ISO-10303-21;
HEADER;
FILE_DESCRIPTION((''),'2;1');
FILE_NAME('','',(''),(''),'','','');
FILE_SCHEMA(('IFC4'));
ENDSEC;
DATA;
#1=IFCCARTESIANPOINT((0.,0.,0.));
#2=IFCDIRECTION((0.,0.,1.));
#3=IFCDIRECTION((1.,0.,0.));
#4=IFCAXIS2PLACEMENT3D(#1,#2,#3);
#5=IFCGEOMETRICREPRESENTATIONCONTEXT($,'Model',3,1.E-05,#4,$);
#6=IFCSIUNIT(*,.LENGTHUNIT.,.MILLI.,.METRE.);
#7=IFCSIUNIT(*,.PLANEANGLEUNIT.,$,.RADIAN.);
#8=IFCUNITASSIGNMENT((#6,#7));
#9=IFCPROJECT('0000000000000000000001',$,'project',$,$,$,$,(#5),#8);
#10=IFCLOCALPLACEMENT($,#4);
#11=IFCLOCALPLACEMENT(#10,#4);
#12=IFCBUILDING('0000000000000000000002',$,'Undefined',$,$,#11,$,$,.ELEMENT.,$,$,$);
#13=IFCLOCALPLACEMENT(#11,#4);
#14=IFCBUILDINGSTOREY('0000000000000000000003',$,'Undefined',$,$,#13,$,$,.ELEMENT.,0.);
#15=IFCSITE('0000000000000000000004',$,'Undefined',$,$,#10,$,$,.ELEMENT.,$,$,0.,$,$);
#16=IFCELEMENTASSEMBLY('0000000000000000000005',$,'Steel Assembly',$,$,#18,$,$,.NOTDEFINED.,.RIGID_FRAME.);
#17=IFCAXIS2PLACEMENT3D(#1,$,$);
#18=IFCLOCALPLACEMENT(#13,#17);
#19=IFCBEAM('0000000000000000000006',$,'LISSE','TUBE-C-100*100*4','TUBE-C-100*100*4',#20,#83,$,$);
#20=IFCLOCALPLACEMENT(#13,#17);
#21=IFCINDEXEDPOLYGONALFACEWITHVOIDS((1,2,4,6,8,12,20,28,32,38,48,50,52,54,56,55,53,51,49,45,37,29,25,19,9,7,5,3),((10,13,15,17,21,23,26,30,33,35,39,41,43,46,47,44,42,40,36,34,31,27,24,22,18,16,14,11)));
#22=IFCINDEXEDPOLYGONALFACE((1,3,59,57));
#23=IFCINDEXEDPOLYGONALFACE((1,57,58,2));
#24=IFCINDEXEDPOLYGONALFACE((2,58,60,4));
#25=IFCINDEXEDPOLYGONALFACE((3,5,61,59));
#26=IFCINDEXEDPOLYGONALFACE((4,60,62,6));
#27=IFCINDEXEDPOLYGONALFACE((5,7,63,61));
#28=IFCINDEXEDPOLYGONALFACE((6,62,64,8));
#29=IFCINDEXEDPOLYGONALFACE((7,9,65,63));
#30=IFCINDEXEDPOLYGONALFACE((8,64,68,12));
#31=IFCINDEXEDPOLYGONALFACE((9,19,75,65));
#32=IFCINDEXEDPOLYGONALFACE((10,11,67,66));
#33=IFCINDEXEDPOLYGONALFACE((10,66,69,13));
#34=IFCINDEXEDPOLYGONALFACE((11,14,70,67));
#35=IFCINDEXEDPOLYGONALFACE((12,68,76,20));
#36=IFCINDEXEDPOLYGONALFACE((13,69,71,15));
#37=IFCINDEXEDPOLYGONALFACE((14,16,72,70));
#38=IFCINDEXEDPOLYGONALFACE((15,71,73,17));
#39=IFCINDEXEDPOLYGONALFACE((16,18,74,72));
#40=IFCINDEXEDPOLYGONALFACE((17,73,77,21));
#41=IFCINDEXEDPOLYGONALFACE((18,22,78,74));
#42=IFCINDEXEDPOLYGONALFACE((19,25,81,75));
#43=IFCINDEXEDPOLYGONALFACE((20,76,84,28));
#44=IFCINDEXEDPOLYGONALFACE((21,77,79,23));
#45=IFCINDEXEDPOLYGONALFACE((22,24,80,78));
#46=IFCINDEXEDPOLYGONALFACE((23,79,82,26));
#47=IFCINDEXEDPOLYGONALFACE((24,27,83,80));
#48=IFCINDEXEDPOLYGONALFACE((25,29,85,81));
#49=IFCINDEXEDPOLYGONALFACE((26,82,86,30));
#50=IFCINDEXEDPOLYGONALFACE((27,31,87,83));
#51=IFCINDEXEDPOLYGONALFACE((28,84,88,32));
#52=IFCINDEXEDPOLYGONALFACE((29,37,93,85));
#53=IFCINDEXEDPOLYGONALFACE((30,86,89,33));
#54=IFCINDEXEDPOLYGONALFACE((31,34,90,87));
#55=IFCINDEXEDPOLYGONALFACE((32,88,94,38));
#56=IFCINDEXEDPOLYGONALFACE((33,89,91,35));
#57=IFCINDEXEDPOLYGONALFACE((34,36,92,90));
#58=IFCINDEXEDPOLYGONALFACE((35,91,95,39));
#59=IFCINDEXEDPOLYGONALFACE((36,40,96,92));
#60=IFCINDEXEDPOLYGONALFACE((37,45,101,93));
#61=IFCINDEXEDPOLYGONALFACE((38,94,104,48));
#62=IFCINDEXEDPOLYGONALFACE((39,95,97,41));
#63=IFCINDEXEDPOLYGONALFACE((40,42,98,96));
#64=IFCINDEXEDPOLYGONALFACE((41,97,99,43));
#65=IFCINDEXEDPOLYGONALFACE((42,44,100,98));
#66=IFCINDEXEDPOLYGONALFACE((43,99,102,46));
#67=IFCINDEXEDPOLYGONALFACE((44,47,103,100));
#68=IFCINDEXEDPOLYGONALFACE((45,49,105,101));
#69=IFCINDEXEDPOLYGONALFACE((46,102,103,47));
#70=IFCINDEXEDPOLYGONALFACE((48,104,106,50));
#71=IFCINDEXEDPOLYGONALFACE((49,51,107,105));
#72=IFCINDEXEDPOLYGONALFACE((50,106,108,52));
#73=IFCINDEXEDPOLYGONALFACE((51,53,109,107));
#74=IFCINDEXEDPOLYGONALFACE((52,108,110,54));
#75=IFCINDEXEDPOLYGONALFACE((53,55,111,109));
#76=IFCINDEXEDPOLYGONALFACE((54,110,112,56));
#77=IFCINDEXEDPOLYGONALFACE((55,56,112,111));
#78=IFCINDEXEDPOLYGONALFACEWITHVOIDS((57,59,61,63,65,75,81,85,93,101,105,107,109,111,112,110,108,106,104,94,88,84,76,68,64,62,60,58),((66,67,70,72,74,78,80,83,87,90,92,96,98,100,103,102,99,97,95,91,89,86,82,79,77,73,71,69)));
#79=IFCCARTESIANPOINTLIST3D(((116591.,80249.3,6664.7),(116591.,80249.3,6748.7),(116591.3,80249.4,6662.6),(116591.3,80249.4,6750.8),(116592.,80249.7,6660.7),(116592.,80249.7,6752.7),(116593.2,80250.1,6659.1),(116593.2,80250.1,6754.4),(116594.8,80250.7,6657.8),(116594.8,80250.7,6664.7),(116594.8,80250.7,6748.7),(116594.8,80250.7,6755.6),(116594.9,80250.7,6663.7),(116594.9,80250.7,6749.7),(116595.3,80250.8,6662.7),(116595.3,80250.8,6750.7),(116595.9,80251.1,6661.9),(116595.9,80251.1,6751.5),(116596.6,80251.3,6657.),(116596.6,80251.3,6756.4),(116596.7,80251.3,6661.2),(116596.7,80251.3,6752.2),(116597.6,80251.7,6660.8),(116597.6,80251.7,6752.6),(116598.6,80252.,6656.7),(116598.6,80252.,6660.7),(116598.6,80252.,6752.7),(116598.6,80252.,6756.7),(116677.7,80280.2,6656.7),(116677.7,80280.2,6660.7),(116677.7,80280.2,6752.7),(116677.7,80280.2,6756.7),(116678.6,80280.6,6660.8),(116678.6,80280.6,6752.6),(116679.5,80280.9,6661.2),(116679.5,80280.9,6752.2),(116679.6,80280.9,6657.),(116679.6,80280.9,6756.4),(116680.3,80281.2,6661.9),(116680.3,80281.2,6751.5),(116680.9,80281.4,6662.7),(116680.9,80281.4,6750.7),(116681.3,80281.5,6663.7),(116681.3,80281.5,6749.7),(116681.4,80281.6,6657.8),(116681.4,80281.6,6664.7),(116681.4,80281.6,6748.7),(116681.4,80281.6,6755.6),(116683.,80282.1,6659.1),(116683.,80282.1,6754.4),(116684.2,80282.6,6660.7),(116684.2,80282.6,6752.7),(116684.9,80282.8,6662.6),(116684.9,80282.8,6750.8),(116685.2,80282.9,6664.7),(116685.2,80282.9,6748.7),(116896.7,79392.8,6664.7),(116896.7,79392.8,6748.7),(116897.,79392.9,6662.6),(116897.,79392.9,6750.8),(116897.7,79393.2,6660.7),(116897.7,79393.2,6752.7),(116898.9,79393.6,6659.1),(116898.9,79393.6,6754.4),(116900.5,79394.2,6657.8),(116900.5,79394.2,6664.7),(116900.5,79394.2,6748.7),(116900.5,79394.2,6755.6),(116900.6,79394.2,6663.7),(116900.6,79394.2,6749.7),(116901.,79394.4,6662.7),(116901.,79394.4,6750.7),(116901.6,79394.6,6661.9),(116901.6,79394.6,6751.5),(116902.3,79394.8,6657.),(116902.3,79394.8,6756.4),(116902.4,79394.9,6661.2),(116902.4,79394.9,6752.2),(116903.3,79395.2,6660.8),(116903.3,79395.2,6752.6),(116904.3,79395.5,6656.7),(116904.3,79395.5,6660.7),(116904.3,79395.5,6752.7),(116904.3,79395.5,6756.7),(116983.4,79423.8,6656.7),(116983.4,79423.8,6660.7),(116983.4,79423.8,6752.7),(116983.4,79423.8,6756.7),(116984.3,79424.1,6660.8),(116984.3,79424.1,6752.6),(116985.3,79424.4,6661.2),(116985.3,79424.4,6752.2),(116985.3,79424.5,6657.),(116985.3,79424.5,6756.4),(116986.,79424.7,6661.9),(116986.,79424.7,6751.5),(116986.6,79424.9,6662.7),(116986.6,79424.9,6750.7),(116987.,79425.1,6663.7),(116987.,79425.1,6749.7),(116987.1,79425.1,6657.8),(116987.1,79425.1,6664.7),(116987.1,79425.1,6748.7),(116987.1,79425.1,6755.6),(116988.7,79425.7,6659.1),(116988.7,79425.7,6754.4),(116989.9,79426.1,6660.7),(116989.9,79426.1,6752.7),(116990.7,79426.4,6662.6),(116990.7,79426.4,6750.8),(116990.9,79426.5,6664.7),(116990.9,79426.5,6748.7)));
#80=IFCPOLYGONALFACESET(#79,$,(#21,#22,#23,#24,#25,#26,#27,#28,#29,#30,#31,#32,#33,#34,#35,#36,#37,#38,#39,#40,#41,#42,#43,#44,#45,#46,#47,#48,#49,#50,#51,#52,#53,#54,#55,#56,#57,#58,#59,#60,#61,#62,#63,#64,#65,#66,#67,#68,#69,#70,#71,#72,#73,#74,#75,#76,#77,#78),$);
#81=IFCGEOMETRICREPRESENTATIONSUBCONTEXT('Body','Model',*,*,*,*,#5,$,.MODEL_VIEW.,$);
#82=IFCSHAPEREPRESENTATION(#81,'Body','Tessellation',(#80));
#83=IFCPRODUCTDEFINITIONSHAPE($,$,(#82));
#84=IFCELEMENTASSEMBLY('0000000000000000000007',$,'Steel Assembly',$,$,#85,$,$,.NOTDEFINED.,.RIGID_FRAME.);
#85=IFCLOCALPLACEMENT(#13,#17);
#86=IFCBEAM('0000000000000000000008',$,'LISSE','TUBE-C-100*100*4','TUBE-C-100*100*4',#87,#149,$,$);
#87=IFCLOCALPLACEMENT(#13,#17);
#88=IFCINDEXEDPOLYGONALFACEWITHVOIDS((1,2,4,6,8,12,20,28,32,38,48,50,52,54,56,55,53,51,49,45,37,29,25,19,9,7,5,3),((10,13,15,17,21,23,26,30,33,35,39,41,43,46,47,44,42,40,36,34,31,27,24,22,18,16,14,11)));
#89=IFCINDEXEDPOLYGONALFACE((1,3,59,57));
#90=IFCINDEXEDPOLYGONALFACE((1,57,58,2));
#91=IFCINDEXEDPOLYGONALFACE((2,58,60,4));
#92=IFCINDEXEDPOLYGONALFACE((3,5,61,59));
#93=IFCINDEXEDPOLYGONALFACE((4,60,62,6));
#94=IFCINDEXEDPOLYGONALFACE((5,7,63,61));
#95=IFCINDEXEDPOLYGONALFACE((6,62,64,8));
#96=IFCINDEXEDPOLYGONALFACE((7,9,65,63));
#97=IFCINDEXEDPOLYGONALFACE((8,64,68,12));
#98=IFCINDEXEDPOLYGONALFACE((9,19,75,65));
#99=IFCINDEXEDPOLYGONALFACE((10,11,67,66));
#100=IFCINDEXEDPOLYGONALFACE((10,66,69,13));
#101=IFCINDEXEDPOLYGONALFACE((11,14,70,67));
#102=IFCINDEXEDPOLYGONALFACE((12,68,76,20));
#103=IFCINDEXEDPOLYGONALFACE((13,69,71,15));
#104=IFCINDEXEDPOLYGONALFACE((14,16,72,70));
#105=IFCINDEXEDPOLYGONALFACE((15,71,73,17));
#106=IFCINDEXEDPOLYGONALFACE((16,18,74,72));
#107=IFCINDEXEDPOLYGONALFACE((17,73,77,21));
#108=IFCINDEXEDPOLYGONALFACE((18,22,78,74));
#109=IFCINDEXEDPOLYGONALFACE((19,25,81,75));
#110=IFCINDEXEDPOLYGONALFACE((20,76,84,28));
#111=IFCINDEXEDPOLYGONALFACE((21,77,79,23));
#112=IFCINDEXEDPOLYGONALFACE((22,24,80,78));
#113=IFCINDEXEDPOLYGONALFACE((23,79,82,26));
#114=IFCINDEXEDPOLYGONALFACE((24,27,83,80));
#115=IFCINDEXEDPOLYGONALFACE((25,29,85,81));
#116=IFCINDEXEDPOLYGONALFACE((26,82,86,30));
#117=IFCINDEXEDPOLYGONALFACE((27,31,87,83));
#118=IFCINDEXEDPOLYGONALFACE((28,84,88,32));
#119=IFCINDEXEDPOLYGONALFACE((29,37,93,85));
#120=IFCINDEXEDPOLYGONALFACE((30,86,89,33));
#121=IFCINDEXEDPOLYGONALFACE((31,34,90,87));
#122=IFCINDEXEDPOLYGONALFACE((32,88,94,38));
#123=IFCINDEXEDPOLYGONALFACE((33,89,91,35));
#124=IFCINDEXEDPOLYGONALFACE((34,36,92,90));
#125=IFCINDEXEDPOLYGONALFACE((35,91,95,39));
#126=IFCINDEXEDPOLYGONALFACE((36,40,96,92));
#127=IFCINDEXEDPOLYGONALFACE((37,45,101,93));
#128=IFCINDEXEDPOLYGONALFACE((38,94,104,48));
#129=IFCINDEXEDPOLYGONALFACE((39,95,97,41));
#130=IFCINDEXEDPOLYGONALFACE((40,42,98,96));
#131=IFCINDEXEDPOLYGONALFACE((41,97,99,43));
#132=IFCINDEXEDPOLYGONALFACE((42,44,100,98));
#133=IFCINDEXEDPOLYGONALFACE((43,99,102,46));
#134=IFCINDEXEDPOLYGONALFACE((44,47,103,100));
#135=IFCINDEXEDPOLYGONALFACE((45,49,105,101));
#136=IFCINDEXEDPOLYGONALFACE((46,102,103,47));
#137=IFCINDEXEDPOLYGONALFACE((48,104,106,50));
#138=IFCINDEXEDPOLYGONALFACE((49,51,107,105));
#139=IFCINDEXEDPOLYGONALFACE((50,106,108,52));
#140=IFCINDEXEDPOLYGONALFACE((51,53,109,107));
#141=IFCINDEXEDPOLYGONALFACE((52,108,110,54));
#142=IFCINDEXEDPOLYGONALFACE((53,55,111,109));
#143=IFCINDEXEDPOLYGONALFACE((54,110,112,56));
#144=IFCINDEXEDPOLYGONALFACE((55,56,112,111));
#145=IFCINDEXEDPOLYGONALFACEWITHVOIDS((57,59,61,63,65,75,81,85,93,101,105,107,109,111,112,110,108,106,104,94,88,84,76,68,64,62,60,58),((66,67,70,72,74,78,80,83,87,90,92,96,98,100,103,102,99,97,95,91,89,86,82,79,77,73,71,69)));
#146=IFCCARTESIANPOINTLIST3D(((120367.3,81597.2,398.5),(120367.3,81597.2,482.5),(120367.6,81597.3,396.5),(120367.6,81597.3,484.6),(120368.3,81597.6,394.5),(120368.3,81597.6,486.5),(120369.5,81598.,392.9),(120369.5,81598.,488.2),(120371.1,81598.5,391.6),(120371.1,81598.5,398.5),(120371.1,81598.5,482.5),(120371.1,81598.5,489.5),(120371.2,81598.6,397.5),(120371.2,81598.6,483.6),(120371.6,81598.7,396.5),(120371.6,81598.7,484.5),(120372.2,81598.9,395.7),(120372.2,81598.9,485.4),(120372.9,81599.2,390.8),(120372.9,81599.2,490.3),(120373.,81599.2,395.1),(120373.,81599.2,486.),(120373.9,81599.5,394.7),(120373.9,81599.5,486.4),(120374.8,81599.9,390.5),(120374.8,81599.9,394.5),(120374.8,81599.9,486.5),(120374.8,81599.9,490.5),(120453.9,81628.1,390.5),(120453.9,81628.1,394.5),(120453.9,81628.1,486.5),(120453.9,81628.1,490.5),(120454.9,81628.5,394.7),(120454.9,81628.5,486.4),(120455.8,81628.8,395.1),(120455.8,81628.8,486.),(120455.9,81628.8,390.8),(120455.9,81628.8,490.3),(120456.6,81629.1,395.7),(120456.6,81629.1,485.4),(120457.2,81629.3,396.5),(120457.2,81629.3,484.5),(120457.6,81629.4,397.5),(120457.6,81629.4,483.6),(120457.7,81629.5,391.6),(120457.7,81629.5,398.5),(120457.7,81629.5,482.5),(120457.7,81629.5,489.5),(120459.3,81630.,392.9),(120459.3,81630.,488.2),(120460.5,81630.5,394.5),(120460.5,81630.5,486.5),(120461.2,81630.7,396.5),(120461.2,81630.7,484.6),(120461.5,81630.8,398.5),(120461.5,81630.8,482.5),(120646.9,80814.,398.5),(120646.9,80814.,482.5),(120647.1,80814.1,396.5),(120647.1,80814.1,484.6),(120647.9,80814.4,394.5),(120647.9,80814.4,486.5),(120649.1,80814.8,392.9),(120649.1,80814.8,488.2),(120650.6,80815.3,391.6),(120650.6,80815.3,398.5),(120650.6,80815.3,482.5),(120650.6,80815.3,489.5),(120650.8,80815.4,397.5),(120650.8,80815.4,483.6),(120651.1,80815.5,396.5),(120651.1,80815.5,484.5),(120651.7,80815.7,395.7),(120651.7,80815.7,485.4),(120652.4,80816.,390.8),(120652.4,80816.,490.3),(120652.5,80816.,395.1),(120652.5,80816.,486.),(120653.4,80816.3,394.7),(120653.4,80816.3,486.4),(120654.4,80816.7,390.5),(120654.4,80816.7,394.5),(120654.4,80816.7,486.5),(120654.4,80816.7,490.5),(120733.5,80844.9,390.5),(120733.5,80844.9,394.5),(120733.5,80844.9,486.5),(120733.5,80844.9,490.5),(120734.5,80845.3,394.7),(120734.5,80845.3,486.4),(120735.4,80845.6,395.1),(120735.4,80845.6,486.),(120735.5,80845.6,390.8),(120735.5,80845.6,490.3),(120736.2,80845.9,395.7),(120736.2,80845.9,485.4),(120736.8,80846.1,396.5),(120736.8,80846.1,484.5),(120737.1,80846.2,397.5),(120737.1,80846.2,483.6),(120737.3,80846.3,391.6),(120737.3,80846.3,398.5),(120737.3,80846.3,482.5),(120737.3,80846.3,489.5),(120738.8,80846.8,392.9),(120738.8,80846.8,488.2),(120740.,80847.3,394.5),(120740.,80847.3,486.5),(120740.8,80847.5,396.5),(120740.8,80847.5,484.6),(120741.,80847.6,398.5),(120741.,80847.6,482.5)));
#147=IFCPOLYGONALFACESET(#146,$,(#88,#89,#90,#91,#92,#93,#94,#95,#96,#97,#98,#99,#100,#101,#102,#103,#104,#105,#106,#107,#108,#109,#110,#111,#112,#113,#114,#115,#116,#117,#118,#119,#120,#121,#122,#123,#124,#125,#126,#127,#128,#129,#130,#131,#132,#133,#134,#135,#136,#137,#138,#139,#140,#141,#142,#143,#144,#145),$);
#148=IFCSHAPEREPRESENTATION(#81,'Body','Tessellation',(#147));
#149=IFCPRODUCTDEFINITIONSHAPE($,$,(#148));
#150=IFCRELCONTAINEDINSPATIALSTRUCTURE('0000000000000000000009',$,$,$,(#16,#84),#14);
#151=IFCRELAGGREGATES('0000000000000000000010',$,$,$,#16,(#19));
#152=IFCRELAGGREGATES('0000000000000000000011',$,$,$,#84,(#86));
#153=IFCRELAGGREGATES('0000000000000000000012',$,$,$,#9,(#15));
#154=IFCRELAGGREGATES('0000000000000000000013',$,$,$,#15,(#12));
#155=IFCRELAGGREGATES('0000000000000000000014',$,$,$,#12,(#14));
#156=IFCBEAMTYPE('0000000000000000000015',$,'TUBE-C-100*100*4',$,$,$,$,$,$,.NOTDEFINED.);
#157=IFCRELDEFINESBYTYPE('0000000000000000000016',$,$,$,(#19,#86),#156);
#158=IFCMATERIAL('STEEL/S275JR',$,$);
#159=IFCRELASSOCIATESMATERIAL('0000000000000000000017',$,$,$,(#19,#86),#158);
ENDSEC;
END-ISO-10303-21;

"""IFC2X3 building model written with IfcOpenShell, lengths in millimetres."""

from ifc_helpers import new_model, si_unit, frame, origin_with_axes, origin_2d_with_axis, place, context, subcontext, project, spatial, hollow_rectangle, extrude, material, type_object, element, aggregate, save


model = new_model("IFC2X3")

# Units and contexts
model_context = context("Model", 3, precision=1e-05, world=origin_with_axes())
body_context = subcontext(model_context, "Body", "Model", "MODEL_VIEW")
ifc_project = project(units=[si_unit("LENGTHUNIT", "METRE", prefix="MILLI"), si_unit("PLANEANGLEUNIT", "RADIAN")], contexts=[model_context])

# Site, building, storey
site_placement = place(None, origin_with_axes())
site = spatial("IfcSite", under=ifc_project, at=site_placement, Name="Undefined", CompositionType="ELEMENT", RefElevation=0.0)
building_placement = place(site_placement, origin_with_axes())
building = spatial("IfcBuilding", under=site, at=building_placement, Name="Undefined", CompositionType="ELEMENT")
storey_placement = place(building_placement, origin_with_axes())
storey = spatial("IfcBuildingStorey", under=building, at=storey_placement, Name="Undefined", CompositionType="ELEMENT", Elevation=0.0)

# Shared definitions
ifc_material = material(Name="STEEL/S275JR")

# Element assemblies, beams
beam_type_1 = type_object("IfcBeamType", Name="TUBE-C-100*100*4", PredefinedType="NOTDEFINED")
assembly_1_placement = place(storey_placement, origin_with_axes())
assembly_1 = element("IfcElementAssembly", 1, at=assembly_1_placement, inside=storey, Name="Steel Assembly", AssemblyPlace="NOTDEFINED", PredefinedType="RIGID_FRAME")
beam_1_placement = place(assembly_1_placement, frame((116943.8, 79409.6, 6706.7), z_axis=(0.941802, 0.336168, 0.0), x_axis=(-0.336168, 0.941802, 0.0)))
beam_1 = element("IfcBeam", 2, at=beam_1_placement, type_object=beam_type_1, material=ifc_material, Name="LISSE", Description="TUBE-C-100*100*4", ObjectType="TUBE-C-100*100*4", context=body_context, shape_type="SweptSolid", body=[
    extrude(hollow_rectangle(XDim=100.0, YDim=100.0, WallThickness=4.0, InnerFilletRadius=4.0, OuterFilletRadius=8.0, at=origin_2d_with_axis()), frame((909.4, 0.0, 0.0), z_axis=(-1.0, 0.0, 0.0), x_axis=(0.0, -1.0, 0.0)), (0.0, 0.0, 1.0), 909.4),
])
aggregate(assembly_1, [beam_1])
assembly_2_placement = place(storey_placement, origin_with_axes())
assembly_2 = element("IfcElementAssembly", 3, at=assembly_2_placement, inside=storey, Name="Steel Assembly", AssemblyPlace="NOTDEFINED", PredefinedType="RIGID_FRAME")
beam_2_placement = place(assembly_2_placement, frame((120693.9, 80830.8, 440.5), z_axis=(0.941802, 0.336168, 0.0), x_axis=(-0.336168, 0.941802, 0.0)))
beam_2 = element("IfcBeam", 4, at=beam_2_placement, type_object=beam_type_1, material=ifc_material, Name="LISSE", Description="TUBE-C-100*100*4", ObjectType="TUBE-C-100*100*4", context=body_context, shape_type="SweptSolid", body=[
    extrude(hollow_rectangle(XDim=100.0, YDim=100.0, WallThickness=4.0, InnerFilletRadius=4.0, OuterFilletRadius=8.0, at=origin_2d_with_axis()), frame((831.6, 0.0, 0.0), z_axis=(-1.0, 0.0, 0.0), x_axis=(0.0, -1.0, 0.0)), (0.0, 0.0, 1.0), 831.6),
])
aggregate(assembly_2, [beam_2])

save(model, "model.ifc")
